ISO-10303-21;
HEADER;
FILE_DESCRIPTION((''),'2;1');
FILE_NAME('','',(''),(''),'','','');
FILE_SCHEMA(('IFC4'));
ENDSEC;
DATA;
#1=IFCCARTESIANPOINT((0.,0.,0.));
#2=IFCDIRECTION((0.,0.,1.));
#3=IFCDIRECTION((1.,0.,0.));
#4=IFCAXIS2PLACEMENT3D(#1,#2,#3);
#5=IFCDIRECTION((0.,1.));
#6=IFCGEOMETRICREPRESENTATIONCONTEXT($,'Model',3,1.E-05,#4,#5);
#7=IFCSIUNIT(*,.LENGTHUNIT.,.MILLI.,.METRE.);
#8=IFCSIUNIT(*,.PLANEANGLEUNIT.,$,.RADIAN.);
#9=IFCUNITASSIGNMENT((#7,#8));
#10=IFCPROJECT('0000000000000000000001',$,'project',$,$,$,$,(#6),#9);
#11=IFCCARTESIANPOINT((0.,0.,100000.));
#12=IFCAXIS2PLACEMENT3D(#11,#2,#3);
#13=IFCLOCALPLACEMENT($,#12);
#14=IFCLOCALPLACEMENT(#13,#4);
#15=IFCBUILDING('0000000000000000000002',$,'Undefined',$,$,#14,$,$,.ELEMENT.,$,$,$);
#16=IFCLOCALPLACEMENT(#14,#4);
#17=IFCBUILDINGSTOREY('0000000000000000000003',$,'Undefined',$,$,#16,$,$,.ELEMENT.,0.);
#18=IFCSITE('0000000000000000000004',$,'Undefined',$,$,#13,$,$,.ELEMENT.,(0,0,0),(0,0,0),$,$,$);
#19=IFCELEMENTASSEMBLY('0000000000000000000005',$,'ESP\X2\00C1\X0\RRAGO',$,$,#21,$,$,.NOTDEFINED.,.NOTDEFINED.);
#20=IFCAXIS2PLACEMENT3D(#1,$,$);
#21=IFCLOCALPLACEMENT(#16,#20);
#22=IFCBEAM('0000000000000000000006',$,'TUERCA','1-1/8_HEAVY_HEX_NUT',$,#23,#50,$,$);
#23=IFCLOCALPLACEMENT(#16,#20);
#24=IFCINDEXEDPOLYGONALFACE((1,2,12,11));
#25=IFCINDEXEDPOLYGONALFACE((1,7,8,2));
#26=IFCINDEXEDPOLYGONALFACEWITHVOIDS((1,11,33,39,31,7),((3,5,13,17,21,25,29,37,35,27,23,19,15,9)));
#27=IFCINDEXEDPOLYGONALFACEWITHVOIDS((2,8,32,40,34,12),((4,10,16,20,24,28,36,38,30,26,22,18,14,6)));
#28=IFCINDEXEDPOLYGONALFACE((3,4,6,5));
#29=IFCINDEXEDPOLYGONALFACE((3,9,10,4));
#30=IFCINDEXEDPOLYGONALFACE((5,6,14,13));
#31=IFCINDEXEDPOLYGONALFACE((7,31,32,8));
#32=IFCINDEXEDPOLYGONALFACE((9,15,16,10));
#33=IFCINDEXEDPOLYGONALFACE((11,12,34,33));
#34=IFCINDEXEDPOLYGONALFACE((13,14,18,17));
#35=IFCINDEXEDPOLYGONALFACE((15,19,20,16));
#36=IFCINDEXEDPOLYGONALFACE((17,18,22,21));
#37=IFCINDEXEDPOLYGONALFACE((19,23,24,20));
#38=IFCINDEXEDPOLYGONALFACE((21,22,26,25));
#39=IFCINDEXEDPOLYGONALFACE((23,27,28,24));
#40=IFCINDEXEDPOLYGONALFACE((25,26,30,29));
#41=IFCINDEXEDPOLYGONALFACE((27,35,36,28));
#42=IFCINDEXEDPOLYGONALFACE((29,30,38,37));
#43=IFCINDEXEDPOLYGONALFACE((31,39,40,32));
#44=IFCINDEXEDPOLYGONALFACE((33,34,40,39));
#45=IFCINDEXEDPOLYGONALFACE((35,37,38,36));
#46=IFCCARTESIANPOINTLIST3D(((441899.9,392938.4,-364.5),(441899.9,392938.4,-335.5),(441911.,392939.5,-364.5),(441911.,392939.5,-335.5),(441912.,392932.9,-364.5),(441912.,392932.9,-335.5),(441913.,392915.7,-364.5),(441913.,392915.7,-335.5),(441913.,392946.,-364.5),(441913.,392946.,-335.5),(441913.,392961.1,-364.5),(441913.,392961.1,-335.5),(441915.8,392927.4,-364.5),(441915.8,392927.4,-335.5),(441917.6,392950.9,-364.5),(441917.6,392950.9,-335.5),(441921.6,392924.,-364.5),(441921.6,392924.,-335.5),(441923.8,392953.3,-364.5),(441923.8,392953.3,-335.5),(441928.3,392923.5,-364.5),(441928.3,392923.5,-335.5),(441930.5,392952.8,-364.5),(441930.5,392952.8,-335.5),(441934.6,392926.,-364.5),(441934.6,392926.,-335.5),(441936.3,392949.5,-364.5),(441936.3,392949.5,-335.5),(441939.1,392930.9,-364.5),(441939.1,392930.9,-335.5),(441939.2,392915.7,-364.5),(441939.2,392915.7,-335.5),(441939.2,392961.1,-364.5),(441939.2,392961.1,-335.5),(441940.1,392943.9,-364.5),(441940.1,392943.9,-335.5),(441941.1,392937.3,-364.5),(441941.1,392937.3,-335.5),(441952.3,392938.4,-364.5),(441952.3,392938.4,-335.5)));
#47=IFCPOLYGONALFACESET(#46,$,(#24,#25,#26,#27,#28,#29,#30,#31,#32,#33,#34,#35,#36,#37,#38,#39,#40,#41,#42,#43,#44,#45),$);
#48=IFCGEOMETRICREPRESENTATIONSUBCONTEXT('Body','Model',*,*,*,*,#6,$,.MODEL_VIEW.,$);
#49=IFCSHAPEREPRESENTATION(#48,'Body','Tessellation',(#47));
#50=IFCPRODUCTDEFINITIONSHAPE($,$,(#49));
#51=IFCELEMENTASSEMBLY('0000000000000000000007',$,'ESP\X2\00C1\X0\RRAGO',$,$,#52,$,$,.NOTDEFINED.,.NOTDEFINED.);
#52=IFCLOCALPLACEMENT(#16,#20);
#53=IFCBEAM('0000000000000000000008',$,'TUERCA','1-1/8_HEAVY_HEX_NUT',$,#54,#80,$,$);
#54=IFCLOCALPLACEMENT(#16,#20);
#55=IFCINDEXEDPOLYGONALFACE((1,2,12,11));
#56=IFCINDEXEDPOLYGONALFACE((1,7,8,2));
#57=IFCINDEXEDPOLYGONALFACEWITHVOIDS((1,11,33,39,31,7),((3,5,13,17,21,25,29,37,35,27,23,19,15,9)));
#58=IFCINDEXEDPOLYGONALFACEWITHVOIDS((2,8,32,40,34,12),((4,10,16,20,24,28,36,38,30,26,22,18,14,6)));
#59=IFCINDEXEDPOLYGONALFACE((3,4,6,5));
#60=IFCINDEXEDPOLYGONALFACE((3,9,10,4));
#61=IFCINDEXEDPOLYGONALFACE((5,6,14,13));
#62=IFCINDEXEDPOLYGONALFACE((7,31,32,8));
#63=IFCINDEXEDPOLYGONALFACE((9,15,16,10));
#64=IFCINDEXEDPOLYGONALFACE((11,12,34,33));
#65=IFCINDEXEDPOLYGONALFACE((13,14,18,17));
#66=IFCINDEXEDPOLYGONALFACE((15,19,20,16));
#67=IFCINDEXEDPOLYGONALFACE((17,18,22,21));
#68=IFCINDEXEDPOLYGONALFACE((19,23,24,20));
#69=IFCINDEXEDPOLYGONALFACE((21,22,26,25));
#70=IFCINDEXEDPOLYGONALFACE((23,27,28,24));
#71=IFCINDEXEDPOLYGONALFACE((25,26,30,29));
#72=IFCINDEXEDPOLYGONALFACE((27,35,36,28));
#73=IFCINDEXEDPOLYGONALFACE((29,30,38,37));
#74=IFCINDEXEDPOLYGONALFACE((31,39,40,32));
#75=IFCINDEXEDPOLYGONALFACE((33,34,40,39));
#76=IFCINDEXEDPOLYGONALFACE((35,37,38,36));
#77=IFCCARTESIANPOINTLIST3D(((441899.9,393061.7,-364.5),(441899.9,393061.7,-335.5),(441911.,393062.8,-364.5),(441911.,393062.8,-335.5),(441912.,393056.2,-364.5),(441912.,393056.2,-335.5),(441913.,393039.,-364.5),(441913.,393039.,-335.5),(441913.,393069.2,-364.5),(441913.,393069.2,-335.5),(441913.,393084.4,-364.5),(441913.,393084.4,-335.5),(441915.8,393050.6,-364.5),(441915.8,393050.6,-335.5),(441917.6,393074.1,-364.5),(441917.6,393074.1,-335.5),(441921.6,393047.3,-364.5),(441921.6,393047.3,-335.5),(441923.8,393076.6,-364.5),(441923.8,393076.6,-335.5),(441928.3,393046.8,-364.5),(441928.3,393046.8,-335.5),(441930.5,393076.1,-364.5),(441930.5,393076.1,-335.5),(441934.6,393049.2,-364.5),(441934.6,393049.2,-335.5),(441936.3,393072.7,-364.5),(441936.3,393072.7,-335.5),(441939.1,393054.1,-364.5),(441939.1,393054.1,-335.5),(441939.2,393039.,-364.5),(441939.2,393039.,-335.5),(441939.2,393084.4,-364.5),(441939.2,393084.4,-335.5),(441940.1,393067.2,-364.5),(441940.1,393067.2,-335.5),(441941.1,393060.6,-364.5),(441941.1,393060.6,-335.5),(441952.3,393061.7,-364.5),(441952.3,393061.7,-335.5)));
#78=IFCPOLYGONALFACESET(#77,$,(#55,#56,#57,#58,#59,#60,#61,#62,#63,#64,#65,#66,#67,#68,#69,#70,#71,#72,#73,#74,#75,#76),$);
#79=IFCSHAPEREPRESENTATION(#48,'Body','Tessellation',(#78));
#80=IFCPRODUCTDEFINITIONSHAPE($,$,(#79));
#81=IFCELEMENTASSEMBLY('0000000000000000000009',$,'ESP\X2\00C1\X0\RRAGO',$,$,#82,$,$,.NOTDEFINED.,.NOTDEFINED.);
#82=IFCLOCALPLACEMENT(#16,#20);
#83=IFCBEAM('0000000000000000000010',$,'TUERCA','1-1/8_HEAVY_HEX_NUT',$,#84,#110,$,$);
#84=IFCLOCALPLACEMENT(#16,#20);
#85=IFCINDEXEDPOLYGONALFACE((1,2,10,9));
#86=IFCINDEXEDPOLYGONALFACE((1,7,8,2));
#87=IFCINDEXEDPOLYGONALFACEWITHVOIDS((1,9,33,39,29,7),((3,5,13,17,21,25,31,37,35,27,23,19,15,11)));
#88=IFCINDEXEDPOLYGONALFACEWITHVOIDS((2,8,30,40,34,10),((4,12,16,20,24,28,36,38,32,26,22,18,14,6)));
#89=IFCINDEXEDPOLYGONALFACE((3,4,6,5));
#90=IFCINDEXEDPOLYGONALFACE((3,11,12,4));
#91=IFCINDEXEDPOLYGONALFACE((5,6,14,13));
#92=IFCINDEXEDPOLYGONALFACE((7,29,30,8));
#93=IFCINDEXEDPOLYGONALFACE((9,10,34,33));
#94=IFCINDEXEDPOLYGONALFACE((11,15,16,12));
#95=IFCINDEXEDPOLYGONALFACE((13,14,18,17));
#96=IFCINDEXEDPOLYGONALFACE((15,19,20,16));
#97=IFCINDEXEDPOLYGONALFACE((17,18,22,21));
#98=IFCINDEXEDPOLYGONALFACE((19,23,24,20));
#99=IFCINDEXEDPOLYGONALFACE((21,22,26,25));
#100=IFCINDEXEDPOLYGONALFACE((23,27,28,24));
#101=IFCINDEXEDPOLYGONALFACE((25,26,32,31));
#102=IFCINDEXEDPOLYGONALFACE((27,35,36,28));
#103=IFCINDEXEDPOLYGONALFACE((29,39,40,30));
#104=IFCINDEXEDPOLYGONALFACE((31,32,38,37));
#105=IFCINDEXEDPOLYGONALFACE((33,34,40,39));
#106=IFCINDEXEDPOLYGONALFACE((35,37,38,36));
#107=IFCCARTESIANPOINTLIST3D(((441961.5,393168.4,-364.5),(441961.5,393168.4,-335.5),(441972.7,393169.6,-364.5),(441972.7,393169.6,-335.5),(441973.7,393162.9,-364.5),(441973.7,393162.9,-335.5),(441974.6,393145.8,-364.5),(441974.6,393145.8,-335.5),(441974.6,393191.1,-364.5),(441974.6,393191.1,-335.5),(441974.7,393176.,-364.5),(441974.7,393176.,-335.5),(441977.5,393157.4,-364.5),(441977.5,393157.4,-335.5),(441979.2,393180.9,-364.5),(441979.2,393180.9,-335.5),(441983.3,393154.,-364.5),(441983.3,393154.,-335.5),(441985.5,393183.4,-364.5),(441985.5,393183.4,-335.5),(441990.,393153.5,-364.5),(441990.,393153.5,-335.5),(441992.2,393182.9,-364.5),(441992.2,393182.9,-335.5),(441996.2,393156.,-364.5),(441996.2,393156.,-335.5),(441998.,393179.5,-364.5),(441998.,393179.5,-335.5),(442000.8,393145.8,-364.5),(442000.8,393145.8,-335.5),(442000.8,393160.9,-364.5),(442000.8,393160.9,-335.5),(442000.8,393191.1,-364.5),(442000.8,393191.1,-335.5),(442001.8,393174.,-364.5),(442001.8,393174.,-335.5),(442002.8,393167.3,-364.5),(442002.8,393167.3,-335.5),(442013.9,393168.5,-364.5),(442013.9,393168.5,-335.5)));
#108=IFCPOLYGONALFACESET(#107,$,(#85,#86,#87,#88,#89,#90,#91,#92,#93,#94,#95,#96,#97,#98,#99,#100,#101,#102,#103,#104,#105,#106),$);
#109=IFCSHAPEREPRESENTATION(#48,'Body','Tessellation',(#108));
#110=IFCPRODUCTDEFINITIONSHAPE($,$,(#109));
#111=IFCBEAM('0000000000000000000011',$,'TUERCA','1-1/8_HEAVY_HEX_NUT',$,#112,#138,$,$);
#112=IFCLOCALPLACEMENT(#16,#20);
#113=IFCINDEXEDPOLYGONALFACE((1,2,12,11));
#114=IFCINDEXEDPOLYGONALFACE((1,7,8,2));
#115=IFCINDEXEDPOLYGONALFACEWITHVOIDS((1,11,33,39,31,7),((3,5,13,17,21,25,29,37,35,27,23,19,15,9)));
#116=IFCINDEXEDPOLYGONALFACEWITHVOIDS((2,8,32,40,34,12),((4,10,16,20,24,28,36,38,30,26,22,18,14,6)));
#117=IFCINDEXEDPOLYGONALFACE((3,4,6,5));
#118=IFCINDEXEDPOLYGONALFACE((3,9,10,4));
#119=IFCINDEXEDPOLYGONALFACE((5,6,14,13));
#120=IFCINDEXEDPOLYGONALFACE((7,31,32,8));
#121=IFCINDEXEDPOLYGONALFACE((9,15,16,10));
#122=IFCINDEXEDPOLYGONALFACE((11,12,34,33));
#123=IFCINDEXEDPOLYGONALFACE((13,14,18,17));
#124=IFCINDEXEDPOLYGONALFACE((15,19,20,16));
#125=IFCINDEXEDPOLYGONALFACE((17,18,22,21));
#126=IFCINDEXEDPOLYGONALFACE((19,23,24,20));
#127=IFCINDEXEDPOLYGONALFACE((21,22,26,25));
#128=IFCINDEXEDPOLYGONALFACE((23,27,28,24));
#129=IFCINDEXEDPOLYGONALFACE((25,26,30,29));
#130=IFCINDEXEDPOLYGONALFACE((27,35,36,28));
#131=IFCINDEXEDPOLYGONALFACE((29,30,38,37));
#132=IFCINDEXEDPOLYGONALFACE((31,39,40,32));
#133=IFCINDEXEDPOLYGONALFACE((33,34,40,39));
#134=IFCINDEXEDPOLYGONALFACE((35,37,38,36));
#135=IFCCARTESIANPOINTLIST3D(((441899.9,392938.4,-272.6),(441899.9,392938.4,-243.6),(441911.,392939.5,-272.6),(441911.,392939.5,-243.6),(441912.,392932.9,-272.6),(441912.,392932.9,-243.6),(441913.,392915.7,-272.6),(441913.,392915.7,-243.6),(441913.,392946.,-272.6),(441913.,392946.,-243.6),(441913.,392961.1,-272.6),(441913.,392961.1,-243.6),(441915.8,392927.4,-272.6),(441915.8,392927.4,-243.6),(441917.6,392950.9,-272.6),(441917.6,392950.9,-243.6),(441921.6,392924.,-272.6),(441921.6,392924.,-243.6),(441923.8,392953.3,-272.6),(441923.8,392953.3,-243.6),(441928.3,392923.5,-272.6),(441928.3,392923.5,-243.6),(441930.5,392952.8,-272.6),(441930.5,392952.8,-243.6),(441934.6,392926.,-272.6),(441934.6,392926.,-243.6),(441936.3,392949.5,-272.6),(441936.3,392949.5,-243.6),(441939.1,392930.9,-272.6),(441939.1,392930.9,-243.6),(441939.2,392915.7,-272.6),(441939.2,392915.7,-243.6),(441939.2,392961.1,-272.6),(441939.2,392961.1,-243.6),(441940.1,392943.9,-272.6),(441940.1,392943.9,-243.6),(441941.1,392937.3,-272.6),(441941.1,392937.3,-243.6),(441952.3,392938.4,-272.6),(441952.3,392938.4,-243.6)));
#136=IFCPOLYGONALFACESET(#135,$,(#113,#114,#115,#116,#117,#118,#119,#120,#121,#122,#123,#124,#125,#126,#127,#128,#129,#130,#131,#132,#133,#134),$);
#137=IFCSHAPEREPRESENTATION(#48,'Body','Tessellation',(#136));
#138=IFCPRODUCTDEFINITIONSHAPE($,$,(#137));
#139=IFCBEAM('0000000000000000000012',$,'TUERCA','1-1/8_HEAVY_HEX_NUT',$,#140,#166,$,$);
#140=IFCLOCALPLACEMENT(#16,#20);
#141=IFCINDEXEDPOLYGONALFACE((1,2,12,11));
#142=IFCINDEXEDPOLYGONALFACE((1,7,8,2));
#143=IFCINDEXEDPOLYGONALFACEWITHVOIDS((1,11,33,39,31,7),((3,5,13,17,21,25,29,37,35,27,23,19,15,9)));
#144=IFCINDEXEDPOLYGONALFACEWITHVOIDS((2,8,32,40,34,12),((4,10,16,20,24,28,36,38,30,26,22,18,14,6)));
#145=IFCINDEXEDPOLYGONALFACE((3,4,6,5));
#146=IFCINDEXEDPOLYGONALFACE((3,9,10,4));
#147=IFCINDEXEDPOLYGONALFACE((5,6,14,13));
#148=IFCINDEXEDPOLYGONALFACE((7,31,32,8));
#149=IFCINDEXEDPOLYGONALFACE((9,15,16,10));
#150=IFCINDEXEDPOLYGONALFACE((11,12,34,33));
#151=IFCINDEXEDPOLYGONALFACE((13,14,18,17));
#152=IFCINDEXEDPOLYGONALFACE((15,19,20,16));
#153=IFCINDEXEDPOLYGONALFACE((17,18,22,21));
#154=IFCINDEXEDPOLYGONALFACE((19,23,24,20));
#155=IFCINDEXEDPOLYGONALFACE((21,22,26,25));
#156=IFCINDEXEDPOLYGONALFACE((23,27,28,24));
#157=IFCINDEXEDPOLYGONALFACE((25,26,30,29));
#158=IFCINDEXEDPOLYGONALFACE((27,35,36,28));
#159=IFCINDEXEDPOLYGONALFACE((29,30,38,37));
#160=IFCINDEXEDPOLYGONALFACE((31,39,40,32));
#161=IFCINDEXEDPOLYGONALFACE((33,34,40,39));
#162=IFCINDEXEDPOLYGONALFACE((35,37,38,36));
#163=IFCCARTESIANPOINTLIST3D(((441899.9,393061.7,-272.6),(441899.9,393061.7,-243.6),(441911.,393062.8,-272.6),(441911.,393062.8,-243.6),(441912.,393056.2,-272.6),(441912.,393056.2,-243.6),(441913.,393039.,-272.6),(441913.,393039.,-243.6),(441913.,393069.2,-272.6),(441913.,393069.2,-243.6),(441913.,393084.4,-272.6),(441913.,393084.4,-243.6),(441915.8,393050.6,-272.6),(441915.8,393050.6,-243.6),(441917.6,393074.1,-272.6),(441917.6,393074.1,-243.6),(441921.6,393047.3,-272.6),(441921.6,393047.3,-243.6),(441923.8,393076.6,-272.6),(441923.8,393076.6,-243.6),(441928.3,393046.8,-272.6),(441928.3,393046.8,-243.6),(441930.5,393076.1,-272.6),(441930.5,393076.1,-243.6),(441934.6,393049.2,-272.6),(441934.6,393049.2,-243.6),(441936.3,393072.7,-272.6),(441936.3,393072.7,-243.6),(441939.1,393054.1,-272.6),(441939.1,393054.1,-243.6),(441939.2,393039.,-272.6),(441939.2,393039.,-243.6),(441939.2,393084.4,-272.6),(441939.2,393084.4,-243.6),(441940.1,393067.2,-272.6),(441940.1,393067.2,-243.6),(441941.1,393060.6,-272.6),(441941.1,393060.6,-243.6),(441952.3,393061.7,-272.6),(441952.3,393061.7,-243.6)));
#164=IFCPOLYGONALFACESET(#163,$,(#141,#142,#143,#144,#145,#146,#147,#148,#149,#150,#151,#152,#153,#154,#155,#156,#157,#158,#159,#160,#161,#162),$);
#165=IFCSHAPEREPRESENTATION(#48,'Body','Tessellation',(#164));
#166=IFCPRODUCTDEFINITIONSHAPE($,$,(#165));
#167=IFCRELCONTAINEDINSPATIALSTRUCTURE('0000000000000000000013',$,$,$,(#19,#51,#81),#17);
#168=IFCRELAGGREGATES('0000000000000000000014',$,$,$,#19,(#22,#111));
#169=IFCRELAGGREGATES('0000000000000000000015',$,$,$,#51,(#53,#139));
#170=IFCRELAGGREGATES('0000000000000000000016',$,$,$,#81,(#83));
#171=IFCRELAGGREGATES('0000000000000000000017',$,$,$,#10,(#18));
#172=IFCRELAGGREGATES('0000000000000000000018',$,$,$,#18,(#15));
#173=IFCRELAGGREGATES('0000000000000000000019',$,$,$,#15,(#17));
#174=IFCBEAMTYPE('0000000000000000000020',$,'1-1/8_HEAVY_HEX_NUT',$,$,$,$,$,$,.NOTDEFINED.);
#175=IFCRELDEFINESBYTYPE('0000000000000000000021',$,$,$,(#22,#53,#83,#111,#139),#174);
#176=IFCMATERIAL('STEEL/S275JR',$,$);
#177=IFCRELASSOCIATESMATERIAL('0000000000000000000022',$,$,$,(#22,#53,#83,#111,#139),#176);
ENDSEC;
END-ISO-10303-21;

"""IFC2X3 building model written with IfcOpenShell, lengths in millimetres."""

from ifc_helpers import new_model, si_unit, direction, frame, origin_with_axes, place, context, subcontext, project, spatial, polyline, outline, extrude, material, type_object, element, aggregate, save


model = new_model("IFC2X3")

# Units and contexts
model_context = context("Model", 3, precision=1e-05, world=origin_with_axes(), true_north=direction((0.0, 1.0)))
body_context = subcontext(model_context, "Body", "Model", "MODEL_VIEW")
ifc_project = project(units=[si_unit("LENGTHUNIT", "METRE", prefix="MILLI"), si_unit("PLANEANGLEUNIT", "RADIAN")], contexts=[model_context])

# Site, building, storey
site_placement = place(None, frame((0.0, 0.0, 100000.0), z_axis=(0.0, 0.0, 1.0), x_axis=(1.0, 0.0, 0.0)))
site = spatial("IfcSite", under=ifc_project, at=site_placement, Name="Undefined", CompositionType="ELEMENT", RefLatitude=(0, 0, 0), RefLongitude=(0, 0, 0))
building_placement = place(site_placement, origin_with_axes())
building = spatial("IfcBuilding", under=site, at=building_placement, Name="Undefined", CompositionType="ELEMENT")
storey_placement = place(building_placement, origin_with_axes())
storey = spatial("IfcBuildingStorey", under=building, at=storey_placement, Name="Undefined", CompositionType="ELEMENT", Elevation=0.0)

# Element assemblies, beams
assembly_1_placement = place(storey_placement, origin_with_axes())
assembly_1 = element("IfcElementAssembly", 1, at=assembly_1_placement, inside=storey, Name="ESPÁRRAGO", AssemblyPlace="NOTDEFINED", PredefinedType="NOTDEFINED")
ifc_material_1 = material(Name="STEEL/S275JR")
beam_type_1 = type_object("IfcBeamType", Name="1-1/8_HEAVY_HEX_NUT", PredefinedType="NOTDEFINED")
beam_1_placement = place(assembly_1_placement, frame((441926.1, 392938.4, -335.5), z_axis=(0.866025, -0.5, 0.0), x_axis=(0.0, 0.0, -1.0)))
beam_1 = element("IfcBeam", 2, at=beam_1_placement, type_object=beam_type_1, material=ifc_material_1, Name="TUERCA", Description="1-1/8_HEAVY_HEX_NUT", context=body_context, shape_type="SweptSolid", body=[
    extrude(outline(polyline([(-13.1, -22.7), (-26.2, 0.0), (-13.1, 22.7), (13.1, 22.7), (26.2, 0.0), (13.1, -22.7), (-13.1, -22.7)]), holes=[polyline([(6.5, 13.6), (0.0, 15.1), (-6.5, 13.6), (-11.8, 9.4), (-14.7, 3.4), (-14.7, -3.4), (-11.8, -9.4), (-6.5, -13.6), (0.0, -15.1), (6.5, -13.6), (11.8, -9.4), (14.7, -3.4), (14.7, 3.4), (11.8, 9.4), (6.5, 13.6)])]), frame((29.0, 0.0, 0.0), z_axis=(-1.0, 0.0, 0.0), x_axis=(0.0, -1.0, 0.0)), (0.0, 0.0, 1.0), 29.0),
])
assembly_2_placement = place(storey_placement, origin_with_axes())
assembly_2 = element("IfcElementAssembly", 3, at=assembly_2_placement, inside=storey, Name="ESPÁRRAGO", AssemblyPlace="NOTDEFINED", PredefinedType="NOTDEFINED")
beam_2_placement = place(assembly_2_placement, frame((441926.1, 393061.7, -335.5), z_axis=(0.866025, -0.5, 0.0), x_axis=(0.0, 0.0, -1.0)))
beam_2 = element("IfcBeam", 4, at=beam_2_placement, type_object=beam_type_1, material=ifc_material_1, Name="TUERCA", Description="1-1/8_HEAVY_HEX_NUT", context=body_context, shape_type="SweptSolid", body=[
    extrude(outline(polyline([(-13.1, -22.7), (-26.2, 0.0), (-13.1, 22.7), (13.1, 22.7), (26.2, 0.0), (13.1, -22.7), (-13.1, -22.7)]), holes=[polyline([(6.5, 13.6), (0.0, 15.1), (-6.5, 13.6), (-11.8, 9.4), (-14.7, 3.4), (-14.7, -3.4), (-11.8, -9.4), (-6.5, -13.6), (0.0, -15.1), (6.5, -13.6), (11.8, -9.4), (14.7, -3.4), (14.7, 3.4), (11.8, 9.4), (6.5, 13.6)])]), frame((29.0, 0.0, 0.0), z_axis=(-1.0, 0.0, 0.0), x_axis=(0.0, -1.0, 0.0)), (0.0, 0.0, 1.0), 29.0),
])
assembly_3_placement = place(storey_placement, origin_with_axes())
assembly_3 = element("IfcElementAssembly", 5, at=assembly_3_placement, inside=storey, Name="ESPÁRRAGO", AssemblyPlace="NOTDEFINED", PredefinedType="NOTDEFINED")
beam_3_placement = place(assembly_3_placement, frame((441987.7, 393168.4, -335.5), z_axis=(0.866025, -0.5, 0.0), x_axis=(0.0, 0.0, -1.0)))
beam_3 = element("IfcBeam", 6, at=beam_3_placement, type_object=beam_type_1, material=ifc_material_1, Name="TUERCA", Description="1-1/8_HEAVY_HEX_NUT", context=body_context, shape_type="SweptSolid", body=[
    extrude(outline(polyline([(-13.1, -22.7), (-26.2, 0.0), (-13.1, 22.7), (13.1, 22.7), (26.2, 0.0), (13.1, -22.7), (-13.1, -22.7)]), holes=[polyline([(6.5, 13.6), (0.0, 15.1), (-6.5, 13.6), (-11.8, 9.4), (-14.7, 3.4), (-14.7, -3.4), (-11.8, -9.4), (-6.5, -13.6), (0.0, -15.1), (6.5, -13.6), (11.8, -9.4), (14.7, -3.4), (14.7, 3.4), (11.8, 9.4), (6.5, 13.6)])]), frame((29.0, 0.0, 0.0), z_axis=(-1.0, 0.0, 0.0), x_axis=(0.0, -1.0, 0.0)), (0.0, 0.0, 1.0), 29.0),
])

# Beams
beam_4_placement = place(assembly_1_placement, frame((441926.1, 392938.4, -243.6), z_axis=(0.866025, -0.5, 0.0), x_axis=(0.0, 0.0, -1.0)))
beam_4 = element("IfcBeam", 7, at=beam_4_placement, type_object=beam_type_1, material=ifc_material_1, Name="TUERCA", Description="1-1/8_HEAVY_HEX_NUT", context=body_context, shape_type="SweptSolid", body=[
    extrude(outline(polyline([(-13.1, -22.7), (-26.2, 0.0), (-13.1, 22.7), (13.1, 22.7), (26.2, 0.0), (13.1, -22.7), (-13.1, -22.7)]), holes=[polyline([(6.5, 13.6), (0.0, 15.1), (-6.5, 13.6), (-11.8, 9.4), (-14.7, 3.4), (-14.7, -3.4), (-11.8, -9.4), (-6.5, -13.6), (0.0, -15.1), (6.5, -13.6), (11.8, -9.4), (14.7, -3.4), (14.7, 3.4), (11.8, 9.4), (6.5, 13.6)])]), frame((29.0, 0.0, 0.0), z_axis=(-1.0, 0.0, 0.0), x_axis=(0.0, -1.0, 0.0)), (0.0, 0.0, 1.0), 29.0),
])
beam_5_placement = place(assembly_2_placement, frame((441926.1, 393061.7, -243.6), z_axis=(0.866025, -0.5, 0.0), x_axis=(0.0, 0.0, -1.0)))
beam_5 = element("IfcBeam", 8, at=beam_5_placement, type_object=beam_type_1, material=ifc_material_1, Name="TUERCA", Description="1-1/8_HEAVY_HEX_NUT", context=body_context, shape_type="SweptSolid", body=[
    extrude(outline(polyline([(-13.1, -22.7), (-26.2, 0.0), (-13.1, 22.7), (13.1, 22.7), (26.2, 0.0), (13.1, -22.7), (-13.1, -22.7)]), holes=[polyline([(6.5, 13.6), (0.0, 15.1), (-6.5, 13.6), (-11.8, 9.4), (-14.7, 3.4), (-14.7, -3.4), (-11.8, -9.4), (-6.5, -13.6), (0.0, -15.1), (6.5, -13.6), (11.8, -9.4), (14.7, -3.4), (14.7, 3.4), (11.8, 9.4), (6.5, 13.6)])]), frame((29.0, 0.0, 0.0), z_axis=(-1.0, 0.0, 0.0), x_axis=(0.0, -1.0, 0.0)), (0.0, 0.0, 1.0), 29.0),
])

aggregate(assembly_1, [beam_1, beam_4])
aggregate(assembly_2, [beam_2, beam_5])
aggregate(assembly_3, [beam_3])

save(model, "model.ifc")
